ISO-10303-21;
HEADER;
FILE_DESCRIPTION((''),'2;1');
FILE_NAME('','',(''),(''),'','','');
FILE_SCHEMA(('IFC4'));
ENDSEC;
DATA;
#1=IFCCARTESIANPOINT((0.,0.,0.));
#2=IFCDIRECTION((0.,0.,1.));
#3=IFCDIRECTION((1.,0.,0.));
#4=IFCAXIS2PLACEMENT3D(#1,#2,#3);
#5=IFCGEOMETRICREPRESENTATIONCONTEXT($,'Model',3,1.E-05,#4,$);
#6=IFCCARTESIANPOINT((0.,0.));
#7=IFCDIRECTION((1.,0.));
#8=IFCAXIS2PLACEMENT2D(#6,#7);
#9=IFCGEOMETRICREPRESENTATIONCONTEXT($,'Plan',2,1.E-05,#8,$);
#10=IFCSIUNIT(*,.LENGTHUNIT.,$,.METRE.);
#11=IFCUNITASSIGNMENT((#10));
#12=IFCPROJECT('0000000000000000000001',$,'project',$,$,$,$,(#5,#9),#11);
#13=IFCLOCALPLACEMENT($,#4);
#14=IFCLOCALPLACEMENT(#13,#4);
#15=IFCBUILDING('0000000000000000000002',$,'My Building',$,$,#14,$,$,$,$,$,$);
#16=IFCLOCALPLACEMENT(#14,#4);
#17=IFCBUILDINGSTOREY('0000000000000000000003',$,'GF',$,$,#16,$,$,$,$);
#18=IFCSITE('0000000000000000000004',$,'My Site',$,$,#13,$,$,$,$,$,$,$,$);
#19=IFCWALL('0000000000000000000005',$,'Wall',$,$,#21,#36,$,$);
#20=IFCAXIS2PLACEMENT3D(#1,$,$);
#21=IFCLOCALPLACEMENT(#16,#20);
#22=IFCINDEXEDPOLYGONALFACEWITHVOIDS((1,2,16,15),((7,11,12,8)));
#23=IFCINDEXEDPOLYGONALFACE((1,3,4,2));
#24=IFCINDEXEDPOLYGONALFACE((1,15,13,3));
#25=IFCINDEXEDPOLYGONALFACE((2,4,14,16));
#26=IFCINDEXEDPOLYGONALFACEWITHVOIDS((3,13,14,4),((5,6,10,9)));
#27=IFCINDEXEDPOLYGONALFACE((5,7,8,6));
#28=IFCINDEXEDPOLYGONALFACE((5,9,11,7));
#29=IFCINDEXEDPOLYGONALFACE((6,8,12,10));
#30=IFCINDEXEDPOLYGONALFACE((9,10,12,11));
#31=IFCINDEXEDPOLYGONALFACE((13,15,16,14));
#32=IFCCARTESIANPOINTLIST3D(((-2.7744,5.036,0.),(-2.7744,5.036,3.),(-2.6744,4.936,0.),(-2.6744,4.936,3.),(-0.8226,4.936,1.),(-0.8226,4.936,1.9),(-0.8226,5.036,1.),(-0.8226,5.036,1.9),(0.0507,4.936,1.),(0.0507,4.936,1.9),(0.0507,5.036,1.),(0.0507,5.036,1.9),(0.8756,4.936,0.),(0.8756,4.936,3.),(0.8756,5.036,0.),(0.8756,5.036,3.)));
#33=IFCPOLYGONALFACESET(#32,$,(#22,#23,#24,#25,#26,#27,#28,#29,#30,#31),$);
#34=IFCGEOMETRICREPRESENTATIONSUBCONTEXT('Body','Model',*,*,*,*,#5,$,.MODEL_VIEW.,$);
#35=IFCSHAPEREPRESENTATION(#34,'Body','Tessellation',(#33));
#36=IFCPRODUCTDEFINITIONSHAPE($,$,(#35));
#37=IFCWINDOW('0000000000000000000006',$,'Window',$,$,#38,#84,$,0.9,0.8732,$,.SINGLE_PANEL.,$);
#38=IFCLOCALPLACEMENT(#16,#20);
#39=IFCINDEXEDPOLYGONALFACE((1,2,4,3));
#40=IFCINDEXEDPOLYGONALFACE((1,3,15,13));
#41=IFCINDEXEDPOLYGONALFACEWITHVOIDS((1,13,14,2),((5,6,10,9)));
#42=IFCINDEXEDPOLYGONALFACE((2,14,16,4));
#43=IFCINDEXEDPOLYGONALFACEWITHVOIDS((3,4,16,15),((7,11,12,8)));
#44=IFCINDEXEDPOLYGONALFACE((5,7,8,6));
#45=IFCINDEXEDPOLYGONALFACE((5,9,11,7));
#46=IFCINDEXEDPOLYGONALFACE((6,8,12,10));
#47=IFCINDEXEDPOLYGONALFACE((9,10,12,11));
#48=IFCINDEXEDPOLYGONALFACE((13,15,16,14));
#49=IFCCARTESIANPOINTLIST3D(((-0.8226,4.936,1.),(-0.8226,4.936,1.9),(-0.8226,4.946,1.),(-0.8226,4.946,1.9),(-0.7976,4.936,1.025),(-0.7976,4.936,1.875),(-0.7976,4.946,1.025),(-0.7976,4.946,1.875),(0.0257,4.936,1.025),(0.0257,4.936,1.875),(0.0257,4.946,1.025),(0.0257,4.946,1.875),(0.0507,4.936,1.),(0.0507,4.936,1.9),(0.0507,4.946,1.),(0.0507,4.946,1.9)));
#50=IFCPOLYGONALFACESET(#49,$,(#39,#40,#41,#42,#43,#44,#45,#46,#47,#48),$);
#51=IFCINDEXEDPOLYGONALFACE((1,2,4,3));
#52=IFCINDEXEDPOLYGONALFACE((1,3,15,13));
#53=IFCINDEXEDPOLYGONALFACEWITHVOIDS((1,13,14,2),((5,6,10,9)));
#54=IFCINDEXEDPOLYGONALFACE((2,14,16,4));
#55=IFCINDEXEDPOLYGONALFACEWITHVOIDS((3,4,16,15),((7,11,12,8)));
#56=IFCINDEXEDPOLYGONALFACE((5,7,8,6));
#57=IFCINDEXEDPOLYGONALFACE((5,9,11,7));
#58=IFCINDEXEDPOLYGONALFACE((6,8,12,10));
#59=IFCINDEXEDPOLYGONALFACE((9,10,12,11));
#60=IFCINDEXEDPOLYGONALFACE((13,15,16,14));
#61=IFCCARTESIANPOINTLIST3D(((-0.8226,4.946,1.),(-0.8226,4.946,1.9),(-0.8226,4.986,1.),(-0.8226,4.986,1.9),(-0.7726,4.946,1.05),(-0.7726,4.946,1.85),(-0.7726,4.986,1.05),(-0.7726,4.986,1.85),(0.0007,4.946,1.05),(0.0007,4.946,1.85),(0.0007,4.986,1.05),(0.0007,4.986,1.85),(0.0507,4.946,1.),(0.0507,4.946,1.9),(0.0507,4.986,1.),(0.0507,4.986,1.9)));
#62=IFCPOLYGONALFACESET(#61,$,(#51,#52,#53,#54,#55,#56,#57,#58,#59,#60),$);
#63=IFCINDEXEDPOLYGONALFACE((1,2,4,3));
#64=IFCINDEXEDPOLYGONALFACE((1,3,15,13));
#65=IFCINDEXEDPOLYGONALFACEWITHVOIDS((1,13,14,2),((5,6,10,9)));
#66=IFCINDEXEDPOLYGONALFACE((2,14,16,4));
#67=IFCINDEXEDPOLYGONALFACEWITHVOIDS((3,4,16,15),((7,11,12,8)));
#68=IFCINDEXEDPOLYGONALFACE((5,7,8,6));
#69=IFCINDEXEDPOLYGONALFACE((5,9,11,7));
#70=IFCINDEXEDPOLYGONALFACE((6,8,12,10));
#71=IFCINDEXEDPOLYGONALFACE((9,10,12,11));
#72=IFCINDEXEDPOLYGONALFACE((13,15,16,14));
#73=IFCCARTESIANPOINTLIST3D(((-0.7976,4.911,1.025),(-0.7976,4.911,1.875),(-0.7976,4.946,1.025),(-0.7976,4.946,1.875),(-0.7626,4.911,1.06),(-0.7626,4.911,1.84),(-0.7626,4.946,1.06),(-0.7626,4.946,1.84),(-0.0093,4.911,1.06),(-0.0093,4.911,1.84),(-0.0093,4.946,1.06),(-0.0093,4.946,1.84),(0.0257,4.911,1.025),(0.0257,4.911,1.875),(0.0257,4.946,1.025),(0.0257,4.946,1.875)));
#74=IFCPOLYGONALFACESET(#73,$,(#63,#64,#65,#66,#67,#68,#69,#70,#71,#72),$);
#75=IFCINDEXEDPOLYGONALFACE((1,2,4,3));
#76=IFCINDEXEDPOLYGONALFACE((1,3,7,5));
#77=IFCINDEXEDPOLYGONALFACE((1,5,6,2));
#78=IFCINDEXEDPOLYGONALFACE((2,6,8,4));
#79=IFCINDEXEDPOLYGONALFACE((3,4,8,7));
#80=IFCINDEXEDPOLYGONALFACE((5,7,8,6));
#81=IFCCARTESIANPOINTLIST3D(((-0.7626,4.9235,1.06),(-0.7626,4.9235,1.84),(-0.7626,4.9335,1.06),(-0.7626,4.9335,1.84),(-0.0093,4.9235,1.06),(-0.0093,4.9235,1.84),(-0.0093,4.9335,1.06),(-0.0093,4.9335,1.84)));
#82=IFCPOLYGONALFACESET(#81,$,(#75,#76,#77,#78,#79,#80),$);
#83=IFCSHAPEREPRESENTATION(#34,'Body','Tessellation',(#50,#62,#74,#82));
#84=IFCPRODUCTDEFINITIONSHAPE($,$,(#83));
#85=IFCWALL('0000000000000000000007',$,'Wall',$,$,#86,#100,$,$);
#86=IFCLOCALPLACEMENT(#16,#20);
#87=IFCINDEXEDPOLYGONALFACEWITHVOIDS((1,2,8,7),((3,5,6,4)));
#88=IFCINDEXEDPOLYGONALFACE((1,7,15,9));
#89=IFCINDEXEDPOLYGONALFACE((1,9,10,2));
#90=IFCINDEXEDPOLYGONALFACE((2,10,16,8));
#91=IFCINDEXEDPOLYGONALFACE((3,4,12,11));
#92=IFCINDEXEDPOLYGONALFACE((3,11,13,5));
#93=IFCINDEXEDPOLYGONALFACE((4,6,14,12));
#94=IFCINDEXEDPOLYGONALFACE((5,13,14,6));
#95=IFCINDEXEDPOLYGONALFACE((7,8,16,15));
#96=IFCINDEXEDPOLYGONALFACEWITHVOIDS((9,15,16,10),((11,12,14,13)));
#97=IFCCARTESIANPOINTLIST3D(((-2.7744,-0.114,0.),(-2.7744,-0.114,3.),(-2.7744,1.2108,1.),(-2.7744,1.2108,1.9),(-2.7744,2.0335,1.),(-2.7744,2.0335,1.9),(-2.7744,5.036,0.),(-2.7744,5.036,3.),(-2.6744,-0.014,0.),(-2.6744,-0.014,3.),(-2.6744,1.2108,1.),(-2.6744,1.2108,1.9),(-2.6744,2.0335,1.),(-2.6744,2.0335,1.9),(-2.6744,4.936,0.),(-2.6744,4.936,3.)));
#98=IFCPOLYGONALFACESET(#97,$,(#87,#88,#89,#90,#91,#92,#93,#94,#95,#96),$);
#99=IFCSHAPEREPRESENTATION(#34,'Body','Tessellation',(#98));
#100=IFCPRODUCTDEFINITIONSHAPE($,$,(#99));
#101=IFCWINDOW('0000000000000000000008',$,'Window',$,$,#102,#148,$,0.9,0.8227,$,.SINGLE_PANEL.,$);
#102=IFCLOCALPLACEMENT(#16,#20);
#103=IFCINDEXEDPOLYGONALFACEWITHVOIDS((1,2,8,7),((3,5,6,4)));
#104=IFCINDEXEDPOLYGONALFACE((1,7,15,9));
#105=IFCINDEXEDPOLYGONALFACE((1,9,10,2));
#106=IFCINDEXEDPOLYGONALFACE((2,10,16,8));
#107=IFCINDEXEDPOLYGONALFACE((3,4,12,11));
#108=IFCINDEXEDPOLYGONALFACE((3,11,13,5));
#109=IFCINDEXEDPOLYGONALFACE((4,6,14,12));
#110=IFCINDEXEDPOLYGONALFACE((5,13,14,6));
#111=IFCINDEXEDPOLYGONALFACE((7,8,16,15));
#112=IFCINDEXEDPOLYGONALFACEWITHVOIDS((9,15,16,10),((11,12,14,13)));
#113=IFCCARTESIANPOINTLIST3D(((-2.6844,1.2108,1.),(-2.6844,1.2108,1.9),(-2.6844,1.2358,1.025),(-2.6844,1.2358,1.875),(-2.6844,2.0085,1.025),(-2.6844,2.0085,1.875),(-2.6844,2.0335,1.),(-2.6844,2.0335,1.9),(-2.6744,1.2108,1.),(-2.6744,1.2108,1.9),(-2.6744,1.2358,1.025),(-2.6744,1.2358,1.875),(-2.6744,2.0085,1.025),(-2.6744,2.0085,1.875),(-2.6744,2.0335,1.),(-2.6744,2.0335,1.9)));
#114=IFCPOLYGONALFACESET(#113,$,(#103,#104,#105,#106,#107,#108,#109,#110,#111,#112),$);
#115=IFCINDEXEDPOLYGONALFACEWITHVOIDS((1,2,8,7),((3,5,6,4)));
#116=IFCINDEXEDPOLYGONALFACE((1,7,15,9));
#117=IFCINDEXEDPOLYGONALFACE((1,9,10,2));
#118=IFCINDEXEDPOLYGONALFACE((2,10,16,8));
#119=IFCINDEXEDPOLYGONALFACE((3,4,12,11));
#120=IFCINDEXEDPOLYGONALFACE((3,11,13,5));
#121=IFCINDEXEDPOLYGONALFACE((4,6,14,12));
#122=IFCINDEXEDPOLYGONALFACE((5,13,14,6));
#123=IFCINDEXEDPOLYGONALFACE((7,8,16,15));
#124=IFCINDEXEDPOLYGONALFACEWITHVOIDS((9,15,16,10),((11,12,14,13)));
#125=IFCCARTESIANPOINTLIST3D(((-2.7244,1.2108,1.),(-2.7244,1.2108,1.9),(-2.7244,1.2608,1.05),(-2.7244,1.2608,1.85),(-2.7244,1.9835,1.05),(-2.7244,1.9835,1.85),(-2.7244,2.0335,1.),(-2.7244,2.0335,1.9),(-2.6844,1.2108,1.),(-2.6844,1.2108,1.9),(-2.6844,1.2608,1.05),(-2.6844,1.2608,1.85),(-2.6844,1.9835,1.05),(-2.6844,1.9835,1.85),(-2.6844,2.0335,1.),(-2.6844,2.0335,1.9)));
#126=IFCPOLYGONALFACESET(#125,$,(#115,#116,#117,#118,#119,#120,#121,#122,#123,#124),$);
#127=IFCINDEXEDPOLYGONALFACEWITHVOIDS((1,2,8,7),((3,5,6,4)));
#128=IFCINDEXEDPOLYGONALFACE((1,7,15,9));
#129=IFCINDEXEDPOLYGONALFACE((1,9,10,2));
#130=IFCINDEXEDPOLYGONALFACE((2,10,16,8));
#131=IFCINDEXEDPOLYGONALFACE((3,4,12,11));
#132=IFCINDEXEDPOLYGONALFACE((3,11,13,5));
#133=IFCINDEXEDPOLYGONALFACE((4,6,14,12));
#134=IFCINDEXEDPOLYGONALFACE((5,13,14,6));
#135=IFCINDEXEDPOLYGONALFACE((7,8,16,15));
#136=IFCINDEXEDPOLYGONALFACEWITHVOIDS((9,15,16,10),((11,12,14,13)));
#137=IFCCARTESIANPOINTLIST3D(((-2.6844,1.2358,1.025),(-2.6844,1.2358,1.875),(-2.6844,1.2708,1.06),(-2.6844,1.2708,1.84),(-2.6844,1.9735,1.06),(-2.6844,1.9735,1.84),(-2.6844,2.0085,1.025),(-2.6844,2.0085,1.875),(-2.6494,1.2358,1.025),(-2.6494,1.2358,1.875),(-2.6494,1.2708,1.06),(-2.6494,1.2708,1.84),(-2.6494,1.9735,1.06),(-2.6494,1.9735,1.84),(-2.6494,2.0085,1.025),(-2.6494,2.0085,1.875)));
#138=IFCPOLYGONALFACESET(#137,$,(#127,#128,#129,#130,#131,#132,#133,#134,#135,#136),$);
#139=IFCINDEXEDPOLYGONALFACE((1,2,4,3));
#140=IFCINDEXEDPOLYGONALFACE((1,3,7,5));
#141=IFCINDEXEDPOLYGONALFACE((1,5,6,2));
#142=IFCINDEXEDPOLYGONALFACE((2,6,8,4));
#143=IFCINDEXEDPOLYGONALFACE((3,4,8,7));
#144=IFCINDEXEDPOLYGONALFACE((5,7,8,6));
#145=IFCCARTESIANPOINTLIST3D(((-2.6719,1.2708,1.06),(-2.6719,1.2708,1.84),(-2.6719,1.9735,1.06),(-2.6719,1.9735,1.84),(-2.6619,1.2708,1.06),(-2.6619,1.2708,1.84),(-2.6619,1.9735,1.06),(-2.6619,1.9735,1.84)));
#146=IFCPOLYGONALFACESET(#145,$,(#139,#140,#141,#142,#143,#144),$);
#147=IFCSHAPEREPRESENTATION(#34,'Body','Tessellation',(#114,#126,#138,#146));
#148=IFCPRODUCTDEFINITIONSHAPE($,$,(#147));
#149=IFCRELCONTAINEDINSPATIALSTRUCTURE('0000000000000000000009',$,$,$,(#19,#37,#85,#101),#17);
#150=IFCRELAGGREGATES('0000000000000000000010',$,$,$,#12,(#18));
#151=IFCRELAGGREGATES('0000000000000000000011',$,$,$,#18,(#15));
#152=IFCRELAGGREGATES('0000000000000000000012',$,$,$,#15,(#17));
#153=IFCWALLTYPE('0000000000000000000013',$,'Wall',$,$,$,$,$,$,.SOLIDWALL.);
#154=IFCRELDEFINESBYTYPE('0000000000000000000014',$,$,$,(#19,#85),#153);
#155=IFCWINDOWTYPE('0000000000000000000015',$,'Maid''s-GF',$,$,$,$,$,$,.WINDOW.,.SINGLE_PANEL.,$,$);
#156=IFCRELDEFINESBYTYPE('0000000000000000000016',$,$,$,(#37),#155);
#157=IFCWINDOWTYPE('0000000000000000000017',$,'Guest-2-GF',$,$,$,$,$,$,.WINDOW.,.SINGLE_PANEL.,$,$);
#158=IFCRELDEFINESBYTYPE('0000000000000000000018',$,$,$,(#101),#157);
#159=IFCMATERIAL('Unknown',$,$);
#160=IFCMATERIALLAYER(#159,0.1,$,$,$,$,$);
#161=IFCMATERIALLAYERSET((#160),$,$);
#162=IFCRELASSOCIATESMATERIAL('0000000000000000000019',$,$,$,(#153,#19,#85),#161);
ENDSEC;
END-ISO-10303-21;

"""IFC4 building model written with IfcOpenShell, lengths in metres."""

from ifc_helpers import new_model, entity, si_unit, frame, origin_with_axes, origin_2d_with_axis, place, context, subcontext, project, spatial, line, indexed_curve, outline, extrude, shape, source, transform, mapped, material, layer, layer_set, layer_usage, type_object, type_shapes, element, fill, save


model = new_model("IFC4")

# Units and contexts
model_context = context("Model", 3, precision=1e-05, world=origin_with_axes())
plan_context = context("Plan", 2, precision=1e-05, world=origin_2d_with_axis())
body_context_1 = subcontext(model_context, "Body", "Model", "MODEL_VIEW")
body_context_2 = subcontext(plan_context, "Body", "Plan", "PLAN_VIEW")
ifc_project = project(units=[si_unit("LENGTHUNIT", "METRE")], contexts=[model_context, plan_context])

# Site, building, storey
site_placement = place(None, origin_with_axes())
site = spatial("IfcSite", under=ifc_project, at=site_placement, Name="My Site")
building_placement = place(site_placement, origin_with_axes())
building = spatial("IfcBuilding", under=site, at=building_placement, Name="My Building")
storey_placement = place(building_placement, origin_with_axes())
storey = spatial("IfcBuildingStorey", under=building, at=storey_placement, Name="GF")

# Shared definitions
ifc_material = material(Name="Unknown")

# Shared definitions
ifc_layer_1 = layer(ifc_material, 0.1)
ifc_layer_set_1 = layer_set([ifc_layer_1])
wall_type = type_object("IfcWallType", Name="Wall", PredefinedType="SOLIDWALL", material=ifc_layer_set_1)

# Walls, openings, windows
ifc_layer_usage_1 = layer_usage(ifc_layer_set_1, "AXIS2", "POSITIVE", 0.0)
wall_1_placement = place(storey_placement, frame((0.8756, 5.036, 0.0), z_axis=(0.0, 0.0, 1.0), x_axis=(-1.0, 0.0, 0.0)))
wall_1 = element("IfcWall", 1, at=wall_1_placement, inside=storey, type_object=wall_type, material=ifc_layer_usage_1, Name="Wall", context=body_context_1, shape_type="SweptSolid", body=[
    extrude(outline(indexed_curve([(0.0, 0.0), (0.0, 0.1), (3.55, 0.1), (3.65, 0.0)], segments=[line(1, 2, 3, 4, 1)])), origin_with_axes(), (0.0, 0.0, 1.0), 3.0),
])
shared_shape_1 = source(origin_with_axes(), body_context_1, "Body", "SweptSolid", [
    extrude(outline(indexed_curve([(0.0, 0.0), (0.8732, 0.0), (0.8732, 0.9), (0.0, 0.9)], segments=[line(1, 2, 3, 4, 1)])), frame((0.0, -0.6, 0.0), z_axis=(0.0, -1.0, 0.0), x_axis=(1.0, 0.0, 0.0)), (0.0, 0.0, -1.0), 1.2),
])
opening_1_placement = place(wall_1_placement, frame((0.8249, 0.0, 1.0), z_axis=(0.0, 0.0, 1.0), x_axis=(1.0, 0.0, 0.0)))
opening_1 = element("IfcOpeningElement", 2, at=opening_1_placement, cuts=wall_1, PredefinedType="OPENING", context=body_context_1, shape_type="MappedRepresentation", body=[
    mapped(shared_shape_1, transform((0.0, 0.0, 0.0), x_axis=(1.0, 0.0, 0.0), y_axis=(0.0, 1.0, 0.0), z_axis=(0.0, 0.0, 1.0), scale=1.0)),
])
window_type_1 = type_object("IfcWindowType", Name="Maid's-GF", PartitioningType="SINGLE_PANEL", PredefinedType="WINDOW")
shared_shape_2 = source(origin_with_axes(), body_context_1, "Body", "SweptSolid", [
    extrude(outline(indexed_curve([(0.0, 0.0), (0.8732, 0.0), (0.8732, 0.9), (0.0, 0.9)], segments=[line(1, 2, 3, 4, 1)]), holes=[indexed_curve([(0.025, 0.025), (0.8482, 0.025), (0.8482, 0.875), (0.025, 0.875)], segments=[line(1, 2, 3, 4, 1)])]), frame((0.0, 0.09, 0.0), z_axis=(0.0, -1.0, 0.0), x_axis=(1.0, 0.0, 0.0)), (0.0, 0.0, -1.0), 0.01),
    extrude(outline(indexed_curve([(0.0, 0.0), (0.8732, 0.0), (0.8732, 0.9), (0.0, 0.9)], segments=[line(1, 2, 3, 4, 1)]), holes=[indexed_curve([(0.05, 0.05), (0.8232, 0.05), (0.8232, 0.85), (0.05, 0.85)], segments=[line(1, 2, 3, 4, 1)])]), frame((0.0, 0.05, 0.0), z_axis=(0.0, -1.0, 0.0), x_axis=(1.0, 0.0, 0.0)), (0.0, 0.0, -1.0), 0.04),
    extrude(outline(indexed_curve([(0.0, 0.0), (0.8232, 0.0), (0.8232, 0.85), (0.0, 0.85)], segments=[line(1, 2, 3, 4, 1)]), holes=[indexed_curve([(0.035, 0.035), (0.7882, 0.035), (0.7882, 0.815), (0.035, 0.815)], segments=[line(1, 2, 3, 4, 1)])]), frame((0.025, 0.09, 0.025), z_axis=(0.0, -1.0, 0.0), x_axis=(1.0, 0.0, 0.0)), (0.0, 0.0, -1.0), 0.035),
    extrude(outline(indexed_curve([(0.035, 0.035), (0.7882, 0.035), (0.7882, 0.815), (0.035, 0.815)], segments=[line(1, 2, 3, 4, 1)])), frame((0.025, 0.1025, 0.025), z_axis=(0.0, -1.0, 0.0), x_axis=(1.0, 0.0, 0.0)), (0.0, 0.0, -1.0), 0.01),
])
shared_shape_3 = source(origin_with_axes(), body_context_2, "Body", "Curve2D", [
    entity("IfcIndexedPolyCurve", entity("IfcCartesianPointList2D", [[0.05, 0.05], [0.8232, 0.05]])),
    entity("IfcIndexedPolyCurve", entity("IfcCartesianPointList2D", [[0.0, 0.1], [0.025, 0.1], [0.025, 0.09], [0.05, 0.09], [0.05, 0.05], [0.0, 0.05]]), [entity("IfcLineIndex", [1, 2, 3, 4, 5, 6, 1])]),
    entity("IfcIndexedPolyCurve", entity("IfcCartesianPointList2D", [[0.8732, 0.1], [0.8482, 0.1], [0.8482, 0.09], [0.8232, 0.09], [0.8232, 0.05], [0.8732, 0.05]]), [entity("IfcLineIndex", [1, 2, 3, 4, 5, 6, 1])]),
    entity("IfcIndexedPolyCurve", entity("IfcCartesianPointList2D", [[0.025, 0.09], [0.06, 0.09], [0.06, 0.125], [0.025, 0.125]]), [entity("IfcLineIndex", [1, 2, 3, 4, 1])]),
    entity("IfcIndexedPolyCurve", entity("IfcCartesianPointList2D", [[0.8482, 0.09], [0.8132, 0.09], [0.8132, 0.125], [0.8482, 0.125]]), [entity("IfcLineIndex", [1, 2, 3, 4, 1])]),
    entity("IfcIndexedPolyCurve", entity("IfcCartesianPointList2D", [[0.06, 0.09], [0.8132, 0.09]])),
    entity("IfcIndexedPolyCurve", entity("IfcCartesianPointList2D", [[0.06, 0.125], [0.8132, 0.125]])),
    entity("IfcIndexedPolyCurve", entity("IfcCartesianPointList2D", [[0.06, 0.1075], [0.8132, 0.1075]])),
])
type_shapes(window_type_1, [shared_shape_2, shared_shape_3])
window_1_placement = place(opening_1_placement, frame((0.0, 0.0, 0.0), z_axis=(0.0, 0.0, 1.0), x_axis=(1.0, 0.0, 0.0)))
window_1 = element("IfcWindow", 3, at=window_1_placement, inside=storey, type_object=window_type_1, Name="Window", OverallHeight=0.9, OverallWidth=0.8732, PartitioningType="SINGLE_PANEL", shapes=[
    shape(body_context_1, "Body", "MappedRepresentation", [mapped(shared_shape_2, transform((0.0, 0.0, 0.0), x_axis=(1.0, 0.0, 0.0), y_axis=(0.0, 1.0, 0.0), z_axis=(0.0, 0.0, 1.0), scale=1.0))]),
    shape(body_context_2, "Body", "MappedRepresentation", [mapped(shared_shape_3, transform((0.0, 0.0, 0.0), x_axis=(1.0, 0.0, 0.0), y_axis=(0.0, 1.0, 0.0), z_axis=(0.0, 0.0, 1.0), scale=1.0))]),
])
fill(opening_1, window_1)
ifc_layer_usage_2 = layer_usage(ifc_layer_set_1, "AXIS2", "POSITIVE", 0.0)
wall_2_placement = place(storey_placement, frame((-2.7744, 5.036, 0.0), z_axis=(0.0, 0.0, 1.0), x_axis=(0.0, -1.0, 0.0)))
wall_2 = element("IfcWall", 4, at=wall_2_placement, inside=storey, type_object=wall_type, material=ifc_layer_usage_2, Name="Wall", context=body_context_1, shape_type="SweptSolid", body=[
    extrude(outline(indexed_curve([(0.0, 0.0), (0.1, 0.1), (5.05, 0.1), (5.15, 0.0)], segments=[line(1, 2, 3, 4, 1)])), origin_with_axes(), (0.0, 0.0, 1.0), 3.0),
])
shared_shape_4 = source(origin_with_axes(), body_context_1, "Body", "SweptSolid", [
    extrude(outline(indexed_curve([(0.0, 0.0), (0.8227, 0.0), (0.8227, 0.9), (0.0, 0.9)], segments=[line(1, 2, 3, 4, 1)])), frame((0.0, -0.6, 0.0), z_axis=(0.0, -1.0, 0.0), x_axis=(1.0, 0.0, 0.0)), (0.0, 0.0, -1.0), 1.2),
])
opening_2_placement = place(wall_2_placement, frame((3.0025, 0.0, 1.0), z_axis=(0.0, 0.0, 1.0), x_axis=(1.0, 0.0, 0.0)))
opening_2 = element("IfcOpeningElement", 5, at=opening_2_placement, cuts=wall_2, PredefinedType="OPENING", context=body_context_1, shape_type="MappedRepresentation", body=[
    mapped(shared_shape_4, transform((0.0, 0.0, 0.0), x_axis=(1.0, 0.0, 0.0), y_axis=(0.0, 1.0, 0.0), z_axis=(0.0, 0.0, 1.0), scale=1.0)),
])
window_type_2 = type_object("IfcWindowType", Name="Guest-2-GF", PartitioningType="SINGLE_PANEL", PredefinedType="WINDOW")
shared_shape_5 = source(origin_with_axes(), body_context_1, "Body", "SweptSolid", [
    extrude(outline(indexed_curve([(0.0, 0.0), (0.8227, 0.0), (0.8227, 0.9), (0.0, 0.9)], segments=[line(1, 2, 3, 4, 1)]), holes=[indexed_curve([(0.025, 0.025), (0.7977, 0.025), (0.7977, 0.875), (0.025, 0.875)], segments=[line(1, 2, 3, 4, 1)])]), frame((0.0, 0.09, 0.0), z_axis=(0.0, -1.0, 0.0), x_axis=(1.0, 0.0, 0.0)), (0.0, 0.0, -1.0), 0.01),
    extrude(outline(indexed_curve([(0.0, 0.0), (0.8227, 0.0), (0.8227, 0.9), (0.0, 0.9)], segments=[line(1, 2, 3, 4, 1)]), holes=[indexed_curve([(0.05, 0.05), (0.7727, 0.05), (0.7727, 0.85), (0.05, 0.85)], segments=[line(1, 2, 3, 4, 1)])]), frame((0.0, 0.05, 0.0), z_axis=(0.0, -1.0, 0.0), x_axis=(1.0, 0.0, 0.0)), (0.0, 0.0, -1.0), 0.04),
    extrude(outline(indexed_curve([(0.0, 0.0), (0.7727, 0.0), (0.7727, 0.85), (0.0, 0.85)], segments=[line(1, 2, 3, 4, 1)]), holes=[indexed_curve([(0.035, 0.035), (0.7377, 0.035), (0.7377, 0.815), (0.035, 0.815)], segments=[line(1, 2, 3, 4, 1)])]), frame((0.025, 0.09, 0.025), z_axis=(0.0, -1.0, 0.0), x_axis=(1.0, 0.0, 0.0)), (0.0, 0.0, -1.0), 0.035),
    extrude(outline(indexed_curve([(0.035, 0.035), (0.7377, 0.035), (0.7377, 0.815), (0.035, 0.815)], segments=[line(1, 2, 3, 4, 1)])), frame((0.025, 0.1025, 0.025), z_axis=(0.0, -1.0, 0.0), x_axis=(1.0, 0.0, 0.0)), (0.0, 0.0, -1.0), 0.01),
])
shared_shape_6 = source(origin_with_axes(), body_context_2, "Body", "Curve2D", [
    entity("IfcIndexedPolyCurve", entity("IfcCartesianPointList2D", [[0.05, 0.05], [0.7727, 0.05]])),
    entity("IfcIndexedPolyCurve", entity("IfcCartesianPointList2D", [[0.0, 0.1], [0.025, 0.1], [0.025, 0.09], [0.05, 0.09], [0.05, 0.05], [0.0, 0.05]]), [entity("IfcLineIndex", [1, 2, 3, 4, 5, 6, 1])]),
    entity("IfcIndexedPolyCurve", entity("IfcCartesianPointList2D", [[0.8227, 0.1], [0.7977, 0.1], [0.7977, 0.09], [0.7727, 0.09], [0.7727, 0.05], [0.8227, 0.05]]), [entity("IfcLineIndex", [1, 2, 3, 4, 5, 6, 1])]),
    entity("IfcIndexedPolyCurve", entity("IfcCartesianPointList2D", [[0.025, 0.09], [0.06, 0.09], [0.06, 0.125], [0.025, 0.125]]), [entity("IfcLineIndex", [1, 2, 3, 4, 1])]),
    entity("IfcIndexedPolyCurve", entity("IfcCartesianPointList2D", [[0.7977, 0.09], [0.7627, 0.09], [0.7627, 0.125], [0.7977, 0.125]]), [entity("IfcLineIndex", [1, 2, 3, 4, 1])]),
    entity("IfcIndexedPolyCurve", entity("IfcCartesianPointList2D", [[0.06, 0.09], [0.7627, 0.09]])),
    entity("IfcIndexedPolyCurve", entity("IfcCartesianPointList2D", [[0.06, 0.125], [0.7627, 0.125]])),
    entity("IfcIndexedPolyCurve", entity("IfcCartesianPointList2D", [[0.06, 0.1075], [0.7627, 0.1075]])),
])
type_shapes(window_type_2, [shared_shape_5, shared_shape_6])
window_2_placement = place(opening_2_placement, frame((0.0, 0.0, 0.0), z_axis=(0.0, 0.0, 1.0), x_axis=(1.0, 0.0, 0.0)))
window_2 = element("IfcWindow", 6, at=window_2_placement, inside=storey, type_object=window_type_2, Name="Window", OverallHeight=0.9, OverallWidth=0.8227, PartitioningType="SINGLE_PANEL", shapes=[
    shape(body_context_1, "Body", "MappedRepresentation", [mapped(shared_shape_5, transform((0.0, 0.0, 0.0), x_axis=(1.0, 0.0, 0.0), y_axis=(0.0, 1.0, 0.0), z_axis=(0.0, 0.0, 1.0), scale=1.0))]),
    shape(body_context_2, "Body", "MappedRepresentation", [mapped(shared_shape_6, transform((0.0, 0.0, 0.0), x_axis=(1.0, 0.0, 0.0), y_axis=(0.0, 1.0, 0.0), z_axis=(0.0, 0.0, 1.0), scale=1.0))]),
])
fill(opening_2, window_2)

save(model, "model.ifc")
